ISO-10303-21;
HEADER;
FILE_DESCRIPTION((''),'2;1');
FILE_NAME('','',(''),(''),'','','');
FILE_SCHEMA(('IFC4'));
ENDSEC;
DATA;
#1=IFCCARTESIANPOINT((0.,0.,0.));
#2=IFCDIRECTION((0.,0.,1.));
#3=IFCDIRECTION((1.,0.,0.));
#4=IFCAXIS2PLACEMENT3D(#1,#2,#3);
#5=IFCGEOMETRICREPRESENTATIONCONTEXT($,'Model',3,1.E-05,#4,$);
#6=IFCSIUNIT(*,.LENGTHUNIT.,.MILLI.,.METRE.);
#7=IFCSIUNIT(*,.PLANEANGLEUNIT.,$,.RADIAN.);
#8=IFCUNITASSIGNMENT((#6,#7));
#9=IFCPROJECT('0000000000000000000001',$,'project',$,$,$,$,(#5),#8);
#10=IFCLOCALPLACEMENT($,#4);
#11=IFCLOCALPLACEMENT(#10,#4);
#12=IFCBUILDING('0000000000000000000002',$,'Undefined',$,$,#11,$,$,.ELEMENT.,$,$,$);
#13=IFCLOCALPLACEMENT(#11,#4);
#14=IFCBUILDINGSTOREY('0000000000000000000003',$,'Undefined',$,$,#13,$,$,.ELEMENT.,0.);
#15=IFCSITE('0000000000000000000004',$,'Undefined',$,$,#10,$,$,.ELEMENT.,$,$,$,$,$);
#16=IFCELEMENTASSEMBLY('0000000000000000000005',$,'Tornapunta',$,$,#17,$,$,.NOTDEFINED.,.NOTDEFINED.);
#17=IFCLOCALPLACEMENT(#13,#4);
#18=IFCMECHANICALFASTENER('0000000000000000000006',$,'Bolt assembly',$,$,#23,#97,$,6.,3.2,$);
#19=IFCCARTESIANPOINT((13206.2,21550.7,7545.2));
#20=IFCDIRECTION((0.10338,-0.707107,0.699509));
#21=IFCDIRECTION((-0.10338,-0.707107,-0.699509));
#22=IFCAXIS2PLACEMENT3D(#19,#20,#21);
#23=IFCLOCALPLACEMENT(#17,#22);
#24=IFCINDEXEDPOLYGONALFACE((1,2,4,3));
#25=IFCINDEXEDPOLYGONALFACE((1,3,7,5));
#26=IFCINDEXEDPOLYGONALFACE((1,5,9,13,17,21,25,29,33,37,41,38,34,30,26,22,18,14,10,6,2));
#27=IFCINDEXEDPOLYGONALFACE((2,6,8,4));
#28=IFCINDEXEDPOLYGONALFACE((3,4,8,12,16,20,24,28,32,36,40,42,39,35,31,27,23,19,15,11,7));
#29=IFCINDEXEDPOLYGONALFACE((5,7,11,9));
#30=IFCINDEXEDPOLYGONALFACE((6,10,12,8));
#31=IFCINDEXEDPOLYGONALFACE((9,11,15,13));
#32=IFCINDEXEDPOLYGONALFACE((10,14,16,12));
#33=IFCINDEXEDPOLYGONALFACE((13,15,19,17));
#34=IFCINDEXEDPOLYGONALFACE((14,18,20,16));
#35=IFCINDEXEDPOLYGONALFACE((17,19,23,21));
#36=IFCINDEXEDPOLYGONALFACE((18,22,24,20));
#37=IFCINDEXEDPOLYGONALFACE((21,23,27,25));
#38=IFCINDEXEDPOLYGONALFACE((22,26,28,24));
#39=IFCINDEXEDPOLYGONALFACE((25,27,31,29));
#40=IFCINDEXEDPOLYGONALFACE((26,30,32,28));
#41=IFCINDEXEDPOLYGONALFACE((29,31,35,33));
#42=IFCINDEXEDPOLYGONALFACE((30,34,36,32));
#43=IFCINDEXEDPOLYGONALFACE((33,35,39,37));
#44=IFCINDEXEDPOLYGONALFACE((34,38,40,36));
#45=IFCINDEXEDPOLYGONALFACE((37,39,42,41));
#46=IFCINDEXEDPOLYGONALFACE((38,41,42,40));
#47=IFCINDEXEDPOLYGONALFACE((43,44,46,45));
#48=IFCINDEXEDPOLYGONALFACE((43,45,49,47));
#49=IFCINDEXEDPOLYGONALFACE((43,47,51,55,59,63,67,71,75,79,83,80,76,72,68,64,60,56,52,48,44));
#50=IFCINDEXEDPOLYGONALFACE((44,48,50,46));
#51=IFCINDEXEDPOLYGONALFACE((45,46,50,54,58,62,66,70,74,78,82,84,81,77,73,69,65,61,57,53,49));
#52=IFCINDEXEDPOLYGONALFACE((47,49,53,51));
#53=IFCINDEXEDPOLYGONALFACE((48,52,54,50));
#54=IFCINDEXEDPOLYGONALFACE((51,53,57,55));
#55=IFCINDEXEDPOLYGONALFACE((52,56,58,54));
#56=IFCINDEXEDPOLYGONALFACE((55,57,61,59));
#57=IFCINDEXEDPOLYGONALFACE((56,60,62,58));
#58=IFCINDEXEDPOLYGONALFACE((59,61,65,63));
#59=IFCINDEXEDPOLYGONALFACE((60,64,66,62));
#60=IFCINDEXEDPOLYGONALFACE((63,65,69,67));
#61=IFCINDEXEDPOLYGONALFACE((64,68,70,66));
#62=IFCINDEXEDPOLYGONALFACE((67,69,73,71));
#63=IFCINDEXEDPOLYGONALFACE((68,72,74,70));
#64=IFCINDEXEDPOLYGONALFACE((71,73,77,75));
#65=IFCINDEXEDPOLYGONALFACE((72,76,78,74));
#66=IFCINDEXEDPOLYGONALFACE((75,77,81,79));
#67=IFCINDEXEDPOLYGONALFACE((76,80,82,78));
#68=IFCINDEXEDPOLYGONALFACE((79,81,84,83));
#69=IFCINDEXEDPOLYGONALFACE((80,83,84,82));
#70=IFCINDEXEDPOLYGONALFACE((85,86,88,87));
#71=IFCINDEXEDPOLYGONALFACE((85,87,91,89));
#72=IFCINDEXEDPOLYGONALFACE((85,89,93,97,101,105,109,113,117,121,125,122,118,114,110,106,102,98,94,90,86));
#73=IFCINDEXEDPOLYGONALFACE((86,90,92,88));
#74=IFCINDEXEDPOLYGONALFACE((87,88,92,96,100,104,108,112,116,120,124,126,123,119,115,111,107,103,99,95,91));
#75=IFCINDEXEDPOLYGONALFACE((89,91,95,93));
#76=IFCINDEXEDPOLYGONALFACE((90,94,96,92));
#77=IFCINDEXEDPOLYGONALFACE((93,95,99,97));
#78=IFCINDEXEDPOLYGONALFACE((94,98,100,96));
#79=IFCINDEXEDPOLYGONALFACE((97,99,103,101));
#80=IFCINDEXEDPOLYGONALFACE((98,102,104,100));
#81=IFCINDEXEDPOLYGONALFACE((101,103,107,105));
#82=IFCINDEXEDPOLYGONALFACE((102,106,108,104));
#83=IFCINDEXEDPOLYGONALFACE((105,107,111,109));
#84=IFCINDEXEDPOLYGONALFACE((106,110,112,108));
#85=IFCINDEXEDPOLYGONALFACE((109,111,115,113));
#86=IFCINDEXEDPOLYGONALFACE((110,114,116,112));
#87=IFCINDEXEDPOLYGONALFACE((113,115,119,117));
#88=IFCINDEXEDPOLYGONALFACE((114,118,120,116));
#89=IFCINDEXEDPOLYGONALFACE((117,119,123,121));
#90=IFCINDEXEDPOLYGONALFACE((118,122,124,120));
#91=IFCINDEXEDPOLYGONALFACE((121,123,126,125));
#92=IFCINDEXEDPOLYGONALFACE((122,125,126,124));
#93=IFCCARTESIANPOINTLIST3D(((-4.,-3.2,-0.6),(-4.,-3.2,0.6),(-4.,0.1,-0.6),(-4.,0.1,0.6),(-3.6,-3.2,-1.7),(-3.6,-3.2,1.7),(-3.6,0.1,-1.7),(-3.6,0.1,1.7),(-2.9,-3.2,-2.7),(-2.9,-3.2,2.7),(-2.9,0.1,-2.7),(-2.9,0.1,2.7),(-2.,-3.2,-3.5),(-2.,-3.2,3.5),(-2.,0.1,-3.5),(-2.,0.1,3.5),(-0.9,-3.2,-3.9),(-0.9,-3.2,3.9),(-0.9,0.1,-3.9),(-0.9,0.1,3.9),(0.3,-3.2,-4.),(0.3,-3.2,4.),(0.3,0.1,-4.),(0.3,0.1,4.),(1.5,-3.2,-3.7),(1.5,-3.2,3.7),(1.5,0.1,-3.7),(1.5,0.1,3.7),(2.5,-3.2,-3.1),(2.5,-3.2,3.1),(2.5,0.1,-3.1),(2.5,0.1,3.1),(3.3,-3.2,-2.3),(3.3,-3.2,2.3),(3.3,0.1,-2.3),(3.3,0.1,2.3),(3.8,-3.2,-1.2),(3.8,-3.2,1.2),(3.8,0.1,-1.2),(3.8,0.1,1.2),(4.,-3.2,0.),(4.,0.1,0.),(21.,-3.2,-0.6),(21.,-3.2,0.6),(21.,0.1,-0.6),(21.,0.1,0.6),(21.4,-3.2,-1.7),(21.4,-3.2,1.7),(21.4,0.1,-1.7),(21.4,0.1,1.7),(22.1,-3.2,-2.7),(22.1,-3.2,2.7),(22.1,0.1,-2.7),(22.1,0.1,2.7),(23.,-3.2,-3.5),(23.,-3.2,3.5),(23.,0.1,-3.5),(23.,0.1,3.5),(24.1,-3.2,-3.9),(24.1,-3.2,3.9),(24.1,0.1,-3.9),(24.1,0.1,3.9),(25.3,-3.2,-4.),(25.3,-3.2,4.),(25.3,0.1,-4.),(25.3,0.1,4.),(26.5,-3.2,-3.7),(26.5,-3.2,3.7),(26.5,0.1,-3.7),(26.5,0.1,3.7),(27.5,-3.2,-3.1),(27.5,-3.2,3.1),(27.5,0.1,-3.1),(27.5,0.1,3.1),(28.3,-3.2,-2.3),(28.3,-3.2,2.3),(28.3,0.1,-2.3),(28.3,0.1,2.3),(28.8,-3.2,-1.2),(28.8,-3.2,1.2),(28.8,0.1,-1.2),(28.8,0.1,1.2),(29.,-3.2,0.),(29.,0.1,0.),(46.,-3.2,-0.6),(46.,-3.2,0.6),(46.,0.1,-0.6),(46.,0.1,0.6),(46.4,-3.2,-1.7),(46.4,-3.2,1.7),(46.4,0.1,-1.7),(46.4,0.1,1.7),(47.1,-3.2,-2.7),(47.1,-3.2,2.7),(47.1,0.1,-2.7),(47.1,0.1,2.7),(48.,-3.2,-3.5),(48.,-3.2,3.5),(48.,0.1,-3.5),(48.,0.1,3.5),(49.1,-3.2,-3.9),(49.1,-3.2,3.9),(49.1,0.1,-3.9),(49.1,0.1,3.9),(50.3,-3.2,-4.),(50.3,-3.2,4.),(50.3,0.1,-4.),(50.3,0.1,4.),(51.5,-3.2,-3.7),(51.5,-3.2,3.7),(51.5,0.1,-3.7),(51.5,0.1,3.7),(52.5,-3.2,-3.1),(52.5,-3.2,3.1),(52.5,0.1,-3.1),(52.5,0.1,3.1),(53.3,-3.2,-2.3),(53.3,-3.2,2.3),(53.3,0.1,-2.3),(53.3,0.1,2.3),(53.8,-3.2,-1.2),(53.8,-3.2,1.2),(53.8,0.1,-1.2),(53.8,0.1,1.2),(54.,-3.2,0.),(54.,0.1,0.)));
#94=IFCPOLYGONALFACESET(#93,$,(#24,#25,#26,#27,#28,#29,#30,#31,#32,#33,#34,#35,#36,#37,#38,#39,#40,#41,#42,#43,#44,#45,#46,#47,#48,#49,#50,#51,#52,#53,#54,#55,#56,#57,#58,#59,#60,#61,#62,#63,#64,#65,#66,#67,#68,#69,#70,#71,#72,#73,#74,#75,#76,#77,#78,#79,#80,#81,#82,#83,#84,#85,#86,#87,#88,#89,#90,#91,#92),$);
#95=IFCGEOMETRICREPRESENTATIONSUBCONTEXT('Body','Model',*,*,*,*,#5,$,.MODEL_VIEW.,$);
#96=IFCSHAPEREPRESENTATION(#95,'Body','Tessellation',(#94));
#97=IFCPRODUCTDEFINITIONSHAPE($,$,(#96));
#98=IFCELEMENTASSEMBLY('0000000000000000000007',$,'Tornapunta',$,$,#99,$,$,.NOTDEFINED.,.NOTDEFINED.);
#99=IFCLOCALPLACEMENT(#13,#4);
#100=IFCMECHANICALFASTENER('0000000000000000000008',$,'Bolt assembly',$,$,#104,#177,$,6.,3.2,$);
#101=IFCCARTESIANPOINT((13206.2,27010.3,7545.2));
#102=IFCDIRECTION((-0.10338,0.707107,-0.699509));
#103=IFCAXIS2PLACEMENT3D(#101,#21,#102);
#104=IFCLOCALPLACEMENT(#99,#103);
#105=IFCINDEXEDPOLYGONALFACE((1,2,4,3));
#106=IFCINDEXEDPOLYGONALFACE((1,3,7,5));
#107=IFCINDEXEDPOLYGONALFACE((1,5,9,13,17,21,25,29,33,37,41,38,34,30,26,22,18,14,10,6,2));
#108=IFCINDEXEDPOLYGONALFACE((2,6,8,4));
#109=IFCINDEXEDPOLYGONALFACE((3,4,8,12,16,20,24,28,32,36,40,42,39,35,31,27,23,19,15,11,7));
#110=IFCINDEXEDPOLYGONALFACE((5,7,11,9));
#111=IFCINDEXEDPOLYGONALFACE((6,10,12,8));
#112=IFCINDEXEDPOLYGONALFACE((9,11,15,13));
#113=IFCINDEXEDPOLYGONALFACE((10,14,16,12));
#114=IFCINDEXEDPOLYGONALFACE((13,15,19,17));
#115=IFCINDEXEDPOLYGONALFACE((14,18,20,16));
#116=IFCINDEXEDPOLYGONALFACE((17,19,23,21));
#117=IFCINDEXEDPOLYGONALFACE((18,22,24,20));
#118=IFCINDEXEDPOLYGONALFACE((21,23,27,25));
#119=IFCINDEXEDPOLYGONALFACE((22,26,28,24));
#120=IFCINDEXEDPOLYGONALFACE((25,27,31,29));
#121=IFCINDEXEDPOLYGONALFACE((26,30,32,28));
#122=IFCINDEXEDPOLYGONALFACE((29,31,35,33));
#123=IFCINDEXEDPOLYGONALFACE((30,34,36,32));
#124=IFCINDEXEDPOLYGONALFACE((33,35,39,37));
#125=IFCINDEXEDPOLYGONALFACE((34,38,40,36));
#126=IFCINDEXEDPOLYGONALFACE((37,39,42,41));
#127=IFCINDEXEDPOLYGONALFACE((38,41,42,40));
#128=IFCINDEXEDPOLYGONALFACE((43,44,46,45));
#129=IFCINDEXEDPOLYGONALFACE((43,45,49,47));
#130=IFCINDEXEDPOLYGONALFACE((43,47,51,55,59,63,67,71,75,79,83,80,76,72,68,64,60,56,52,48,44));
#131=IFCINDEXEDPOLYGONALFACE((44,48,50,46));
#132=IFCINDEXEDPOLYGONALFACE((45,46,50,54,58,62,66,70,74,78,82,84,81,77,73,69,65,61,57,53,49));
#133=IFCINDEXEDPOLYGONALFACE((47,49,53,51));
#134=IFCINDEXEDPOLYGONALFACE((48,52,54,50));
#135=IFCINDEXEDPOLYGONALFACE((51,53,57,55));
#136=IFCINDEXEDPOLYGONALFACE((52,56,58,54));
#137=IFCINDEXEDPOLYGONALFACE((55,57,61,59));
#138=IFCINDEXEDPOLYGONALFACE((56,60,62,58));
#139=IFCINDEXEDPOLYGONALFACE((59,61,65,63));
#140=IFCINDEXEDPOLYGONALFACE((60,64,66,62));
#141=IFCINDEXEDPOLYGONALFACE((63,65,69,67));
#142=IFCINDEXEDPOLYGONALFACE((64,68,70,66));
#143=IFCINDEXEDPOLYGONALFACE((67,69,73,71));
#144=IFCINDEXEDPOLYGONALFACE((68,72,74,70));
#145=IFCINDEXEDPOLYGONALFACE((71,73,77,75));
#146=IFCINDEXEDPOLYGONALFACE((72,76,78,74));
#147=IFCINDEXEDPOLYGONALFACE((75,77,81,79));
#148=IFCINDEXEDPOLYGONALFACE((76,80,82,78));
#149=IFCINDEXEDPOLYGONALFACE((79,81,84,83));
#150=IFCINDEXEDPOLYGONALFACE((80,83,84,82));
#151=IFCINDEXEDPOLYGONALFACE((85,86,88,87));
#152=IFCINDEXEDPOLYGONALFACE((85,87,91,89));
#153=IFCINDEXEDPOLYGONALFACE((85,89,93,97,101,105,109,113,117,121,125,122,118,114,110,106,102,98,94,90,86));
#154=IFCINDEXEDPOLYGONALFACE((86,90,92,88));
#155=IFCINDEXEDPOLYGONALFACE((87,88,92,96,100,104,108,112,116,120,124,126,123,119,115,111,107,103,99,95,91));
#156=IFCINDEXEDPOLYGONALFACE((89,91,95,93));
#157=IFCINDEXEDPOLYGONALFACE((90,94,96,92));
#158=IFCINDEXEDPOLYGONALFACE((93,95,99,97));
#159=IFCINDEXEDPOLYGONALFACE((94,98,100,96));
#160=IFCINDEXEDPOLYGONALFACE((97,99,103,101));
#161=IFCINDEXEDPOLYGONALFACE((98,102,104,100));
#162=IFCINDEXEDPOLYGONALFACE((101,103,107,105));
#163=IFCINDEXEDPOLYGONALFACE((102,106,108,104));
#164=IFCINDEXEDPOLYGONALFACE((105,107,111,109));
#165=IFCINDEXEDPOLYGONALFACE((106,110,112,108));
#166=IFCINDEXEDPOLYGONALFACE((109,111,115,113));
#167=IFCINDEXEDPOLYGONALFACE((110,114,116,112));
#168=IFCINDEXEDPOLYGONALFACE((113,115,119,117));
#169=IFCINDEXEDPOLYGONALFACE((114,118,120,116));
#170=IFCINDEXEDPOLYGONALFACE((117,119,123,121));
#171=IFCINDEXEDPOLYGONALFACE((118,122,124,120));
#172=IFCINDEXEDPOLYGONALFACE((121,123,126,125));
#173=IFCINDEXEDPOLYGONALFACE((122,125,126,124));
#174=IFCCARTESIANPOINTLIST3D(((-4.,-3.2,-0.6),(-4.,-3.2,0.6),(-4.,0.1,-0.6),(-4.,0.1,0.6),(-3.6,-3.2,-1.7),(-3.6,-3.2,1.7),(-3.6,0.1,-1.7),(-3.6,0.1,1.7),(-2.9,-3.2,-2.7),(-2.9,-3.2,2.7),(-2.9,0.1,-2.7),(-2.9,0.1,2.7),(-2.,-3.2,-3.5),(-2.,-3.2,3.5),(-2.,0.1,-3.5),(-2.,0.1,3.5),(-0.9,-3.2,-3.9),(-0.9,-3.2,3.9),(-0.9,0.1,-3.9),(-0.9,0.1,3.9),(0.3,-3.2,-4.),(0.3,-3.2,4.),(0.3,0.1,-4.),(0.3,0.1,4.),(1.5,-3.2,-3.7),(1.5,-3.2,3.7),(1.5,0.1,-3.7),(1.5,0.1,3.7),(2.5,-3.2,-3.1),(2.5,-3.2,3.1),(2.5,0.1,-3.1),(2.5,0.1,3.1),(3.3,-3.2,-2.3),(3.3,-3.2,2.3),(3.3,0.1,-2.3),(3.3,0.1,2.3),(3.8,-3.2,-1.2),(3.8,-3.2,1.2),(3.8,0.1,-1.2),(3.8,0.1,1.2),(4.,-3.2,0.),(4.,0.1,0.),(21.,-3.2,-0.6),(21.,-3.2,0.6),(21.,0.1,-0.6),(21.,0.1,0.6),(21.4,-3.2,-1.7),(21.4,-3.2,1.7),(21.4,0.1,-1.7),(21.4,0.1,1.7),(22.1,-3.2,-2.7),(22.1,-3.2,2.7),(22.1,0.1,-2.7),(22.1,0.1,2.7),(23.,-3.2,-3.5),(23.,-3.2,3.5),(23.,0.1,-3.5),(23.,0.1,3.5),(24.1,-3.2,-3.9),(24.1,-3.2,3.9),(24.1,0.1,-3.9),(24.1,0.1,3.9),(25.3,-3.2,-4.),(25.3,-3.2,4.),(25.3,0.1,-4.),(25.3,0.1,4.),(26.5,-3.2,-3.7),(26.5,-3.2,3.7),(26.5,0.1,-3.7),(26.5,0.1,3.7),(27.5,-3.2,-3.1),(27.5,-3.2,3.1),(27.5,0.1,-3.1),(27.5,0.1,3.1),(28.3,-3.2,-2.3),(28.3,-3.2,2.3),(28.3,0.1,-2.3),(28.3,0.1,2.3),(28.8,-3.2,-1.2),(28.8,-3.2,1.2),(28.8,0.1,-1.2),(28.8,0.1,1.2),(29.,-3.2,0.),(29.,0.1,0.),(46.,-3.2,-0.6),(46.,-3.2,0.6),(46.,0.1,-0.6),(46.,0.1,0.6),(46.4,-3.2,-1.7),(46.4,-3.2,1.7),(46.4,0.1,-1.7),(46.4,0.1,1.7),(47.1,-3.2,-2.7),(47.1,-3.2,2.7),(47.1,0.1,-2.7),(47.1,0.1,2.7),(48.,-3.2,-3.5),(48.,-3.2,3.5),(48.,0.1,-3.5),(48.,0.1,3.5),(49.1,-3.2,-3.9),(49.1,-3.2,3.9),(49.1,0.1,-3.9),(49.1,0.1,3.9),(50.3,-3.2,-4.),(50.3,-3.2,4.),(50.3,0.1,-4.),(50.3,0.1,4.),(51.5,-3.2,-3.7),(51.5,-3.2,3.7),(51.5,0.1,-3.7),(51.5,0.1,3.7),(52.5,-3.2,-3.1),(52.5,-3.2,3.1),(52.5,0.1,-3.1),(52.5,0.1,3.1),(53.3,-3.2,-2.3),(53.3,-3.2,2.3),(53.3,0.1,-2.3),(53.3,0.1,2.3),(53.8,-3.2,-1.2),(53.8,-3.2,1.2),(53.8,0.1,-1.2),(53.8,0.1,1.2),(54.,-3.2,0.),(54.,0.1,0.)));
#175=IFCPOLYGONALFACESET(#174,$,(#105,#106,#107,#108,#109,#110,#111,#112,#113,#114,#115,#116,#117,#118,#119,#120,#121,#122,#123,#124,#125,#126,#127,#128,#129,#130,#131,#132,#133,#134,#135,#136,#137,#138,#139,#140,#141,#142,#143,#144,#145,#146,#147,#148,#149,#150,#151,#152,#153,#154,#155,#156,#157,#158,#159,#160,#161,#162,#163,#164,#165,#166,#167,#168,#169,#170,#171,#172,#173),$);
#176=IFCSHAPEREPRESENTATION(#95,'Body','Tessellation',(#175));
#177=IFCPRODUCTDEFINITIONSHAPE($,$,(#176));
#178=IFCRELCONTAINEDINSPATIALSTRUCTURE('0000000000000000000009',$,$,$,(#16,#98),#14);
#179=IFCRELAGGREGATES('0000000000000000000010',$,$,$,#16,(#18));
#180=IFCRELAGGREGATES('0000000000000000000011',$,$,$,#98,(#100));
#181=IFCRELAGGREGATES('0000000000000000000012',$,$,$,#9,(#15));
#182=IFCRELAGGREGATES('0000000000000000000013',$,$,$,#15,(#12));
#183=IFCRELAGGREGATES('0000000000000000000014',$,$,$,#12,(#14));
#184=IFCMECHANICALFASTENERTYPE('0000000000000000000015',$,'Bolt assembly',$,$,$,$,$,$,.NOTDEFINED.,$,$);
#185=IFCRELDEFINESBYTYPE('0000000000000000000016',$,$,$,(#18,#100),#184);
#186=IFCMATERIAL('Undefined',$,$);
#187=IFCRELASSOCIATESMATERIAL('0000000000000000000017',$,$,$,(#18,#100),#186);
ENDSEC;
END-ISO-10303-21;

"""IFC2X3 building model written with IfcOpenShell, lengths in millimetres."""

from ifc_helpers import new_model, si_unit, frame, origin_with_axes, origin_2d_with_axis, place, context, subcontext, project, spatial, circle, extrude, source, transform, mapped, material, type_object, element, aggregate, save


model = new_model("IFC2X3")

# Units and contexts
model_context = context("Model", 3, precision=1e-05, world=origin_with_axes())
body_context = subcontext(model_context, "Body", "Model", "MODEL_VIEW")
ifc_project = project(units=[si_unit("LENGTHUNIT", "METRE", prefix="MILLI"), si_unit("PLANEANGLEUNIT", "RADIAN")], contexts=[model_context])

# Site, building, storey
site_placement = place(None, origin_with_axes())
site = spatial("IfcSite", under=ifc_project, at=site_placement, Name="Undefined", CompositionType="ELEMENT")
building_placement = place(site_placement, origin_with_axes())
building = spatial("IfcBuilding", under=site, at=building_placement, Name="Undefined", CompositionType="ELEMENT")
storey_placement = place(building_placement, origin_with_axes())
storey = spatial("IfcBuildingStorey", under=building, at=storey_placement, Name="Undefined", CompositionType="ELEMENT", Elevation=0.0)

# Shared definitions
ifc_material_1 = material(Name="Undefined")
mechanical_fastener_type = type_object("IfcMechanicalFastenerType", Name="Bolt assembly")

# Element assemblies, mechanical fasteners
shared_shape_1 = source(origin_with_axes(), body_context, "Body", "SweptSolid", [
    extrude(circle(Radius=4.0, at=origin_2d_with_axis()), frame((0.0, -3.2, 0.0), z_axis=(0.0, 1.0, 0.0), x_axis=(1.0, 0.0, 0.0)), (0.0, 0.0, 1.0), 3.3),
])
assembly_1_placement = place(storey_placement, origin_with_axes())
assembly_1 = element("IfcElementAssembly", 1, at=assembly_1_placement, inside=storey, Name="Tornapunta", AssemblyPlace="NOTDEFINED", PredefinedType="NOTDEFINED")
mechanical_fastener_1_placement = place(assembly_1_placement, frame((13206.2, 21550.7, 7545.2), z_axis=(0.10338, -0.707107, 0.699509), x_axis=(-0.10338, -0.707107, -0.699509)))
mechanical_fastener_1 = element("IfcMechanicalFastener", 2, at=mechanical_fastener_1_placement, type_object=mechanical_fastener_type, material=ifc_material_1, Name="Bolt assembly", NominalDiameter=6.0, NominalLength=3.2, context=body_context, shape_type="MappedRepresentation", body=[
    mapped(shared_shape_1, transform((0.0, 0.0, 0.0))),
    mapped(shared_shape_1, transform((25.0, 0.0, 0.0))),
    mapped(shared_shape_1, transform((50.0, 0.0, 0.0))),
])
aggregate(assembly_1, [mechanical_fastener_1])
assembly_2_placement = place(storey_placement, origin_with_axes())
assembly_2 = element("IfcElementAssembly", 3, at=assembly_2_placement, inside=storey, Name="Tornapunta", AssemblyPlace="NOTDEFINED", PredefinedType="NOTDEFINED")
mechanical_fastener_2_placement = place(assembly_2_placement, frame((13206.2, 27010.3, 7545.2), z_axis=(-0.10338, -0.707107, -0.699509), x_axis=(-0.10338, 0.707107, -0.699509)))
mechanical_fastener_2 = element("IfcMechanicalFastener", 4, at=mechanical_fastener_2_placement, type_object=mechanical_fastener_type, material=ifc_material_1, Name="Bolt assembly", NominalDiameter=6.0, NominalLength=3.2, context=body_context, shape_type="MappedRepresentation", body=[
    mapped(shared_shape_1, transform((0.0, 0.0, 0.0))),
    mapped(shared_shape_1, transform((25.0, 0.0, 0.0))),
    mapped(shared_shape_1, transform((50.0, 0.0, 0.0))),
])
aggregate(assembly_2, [mechanical_fastener_2])

save(model, "model.ifc")
